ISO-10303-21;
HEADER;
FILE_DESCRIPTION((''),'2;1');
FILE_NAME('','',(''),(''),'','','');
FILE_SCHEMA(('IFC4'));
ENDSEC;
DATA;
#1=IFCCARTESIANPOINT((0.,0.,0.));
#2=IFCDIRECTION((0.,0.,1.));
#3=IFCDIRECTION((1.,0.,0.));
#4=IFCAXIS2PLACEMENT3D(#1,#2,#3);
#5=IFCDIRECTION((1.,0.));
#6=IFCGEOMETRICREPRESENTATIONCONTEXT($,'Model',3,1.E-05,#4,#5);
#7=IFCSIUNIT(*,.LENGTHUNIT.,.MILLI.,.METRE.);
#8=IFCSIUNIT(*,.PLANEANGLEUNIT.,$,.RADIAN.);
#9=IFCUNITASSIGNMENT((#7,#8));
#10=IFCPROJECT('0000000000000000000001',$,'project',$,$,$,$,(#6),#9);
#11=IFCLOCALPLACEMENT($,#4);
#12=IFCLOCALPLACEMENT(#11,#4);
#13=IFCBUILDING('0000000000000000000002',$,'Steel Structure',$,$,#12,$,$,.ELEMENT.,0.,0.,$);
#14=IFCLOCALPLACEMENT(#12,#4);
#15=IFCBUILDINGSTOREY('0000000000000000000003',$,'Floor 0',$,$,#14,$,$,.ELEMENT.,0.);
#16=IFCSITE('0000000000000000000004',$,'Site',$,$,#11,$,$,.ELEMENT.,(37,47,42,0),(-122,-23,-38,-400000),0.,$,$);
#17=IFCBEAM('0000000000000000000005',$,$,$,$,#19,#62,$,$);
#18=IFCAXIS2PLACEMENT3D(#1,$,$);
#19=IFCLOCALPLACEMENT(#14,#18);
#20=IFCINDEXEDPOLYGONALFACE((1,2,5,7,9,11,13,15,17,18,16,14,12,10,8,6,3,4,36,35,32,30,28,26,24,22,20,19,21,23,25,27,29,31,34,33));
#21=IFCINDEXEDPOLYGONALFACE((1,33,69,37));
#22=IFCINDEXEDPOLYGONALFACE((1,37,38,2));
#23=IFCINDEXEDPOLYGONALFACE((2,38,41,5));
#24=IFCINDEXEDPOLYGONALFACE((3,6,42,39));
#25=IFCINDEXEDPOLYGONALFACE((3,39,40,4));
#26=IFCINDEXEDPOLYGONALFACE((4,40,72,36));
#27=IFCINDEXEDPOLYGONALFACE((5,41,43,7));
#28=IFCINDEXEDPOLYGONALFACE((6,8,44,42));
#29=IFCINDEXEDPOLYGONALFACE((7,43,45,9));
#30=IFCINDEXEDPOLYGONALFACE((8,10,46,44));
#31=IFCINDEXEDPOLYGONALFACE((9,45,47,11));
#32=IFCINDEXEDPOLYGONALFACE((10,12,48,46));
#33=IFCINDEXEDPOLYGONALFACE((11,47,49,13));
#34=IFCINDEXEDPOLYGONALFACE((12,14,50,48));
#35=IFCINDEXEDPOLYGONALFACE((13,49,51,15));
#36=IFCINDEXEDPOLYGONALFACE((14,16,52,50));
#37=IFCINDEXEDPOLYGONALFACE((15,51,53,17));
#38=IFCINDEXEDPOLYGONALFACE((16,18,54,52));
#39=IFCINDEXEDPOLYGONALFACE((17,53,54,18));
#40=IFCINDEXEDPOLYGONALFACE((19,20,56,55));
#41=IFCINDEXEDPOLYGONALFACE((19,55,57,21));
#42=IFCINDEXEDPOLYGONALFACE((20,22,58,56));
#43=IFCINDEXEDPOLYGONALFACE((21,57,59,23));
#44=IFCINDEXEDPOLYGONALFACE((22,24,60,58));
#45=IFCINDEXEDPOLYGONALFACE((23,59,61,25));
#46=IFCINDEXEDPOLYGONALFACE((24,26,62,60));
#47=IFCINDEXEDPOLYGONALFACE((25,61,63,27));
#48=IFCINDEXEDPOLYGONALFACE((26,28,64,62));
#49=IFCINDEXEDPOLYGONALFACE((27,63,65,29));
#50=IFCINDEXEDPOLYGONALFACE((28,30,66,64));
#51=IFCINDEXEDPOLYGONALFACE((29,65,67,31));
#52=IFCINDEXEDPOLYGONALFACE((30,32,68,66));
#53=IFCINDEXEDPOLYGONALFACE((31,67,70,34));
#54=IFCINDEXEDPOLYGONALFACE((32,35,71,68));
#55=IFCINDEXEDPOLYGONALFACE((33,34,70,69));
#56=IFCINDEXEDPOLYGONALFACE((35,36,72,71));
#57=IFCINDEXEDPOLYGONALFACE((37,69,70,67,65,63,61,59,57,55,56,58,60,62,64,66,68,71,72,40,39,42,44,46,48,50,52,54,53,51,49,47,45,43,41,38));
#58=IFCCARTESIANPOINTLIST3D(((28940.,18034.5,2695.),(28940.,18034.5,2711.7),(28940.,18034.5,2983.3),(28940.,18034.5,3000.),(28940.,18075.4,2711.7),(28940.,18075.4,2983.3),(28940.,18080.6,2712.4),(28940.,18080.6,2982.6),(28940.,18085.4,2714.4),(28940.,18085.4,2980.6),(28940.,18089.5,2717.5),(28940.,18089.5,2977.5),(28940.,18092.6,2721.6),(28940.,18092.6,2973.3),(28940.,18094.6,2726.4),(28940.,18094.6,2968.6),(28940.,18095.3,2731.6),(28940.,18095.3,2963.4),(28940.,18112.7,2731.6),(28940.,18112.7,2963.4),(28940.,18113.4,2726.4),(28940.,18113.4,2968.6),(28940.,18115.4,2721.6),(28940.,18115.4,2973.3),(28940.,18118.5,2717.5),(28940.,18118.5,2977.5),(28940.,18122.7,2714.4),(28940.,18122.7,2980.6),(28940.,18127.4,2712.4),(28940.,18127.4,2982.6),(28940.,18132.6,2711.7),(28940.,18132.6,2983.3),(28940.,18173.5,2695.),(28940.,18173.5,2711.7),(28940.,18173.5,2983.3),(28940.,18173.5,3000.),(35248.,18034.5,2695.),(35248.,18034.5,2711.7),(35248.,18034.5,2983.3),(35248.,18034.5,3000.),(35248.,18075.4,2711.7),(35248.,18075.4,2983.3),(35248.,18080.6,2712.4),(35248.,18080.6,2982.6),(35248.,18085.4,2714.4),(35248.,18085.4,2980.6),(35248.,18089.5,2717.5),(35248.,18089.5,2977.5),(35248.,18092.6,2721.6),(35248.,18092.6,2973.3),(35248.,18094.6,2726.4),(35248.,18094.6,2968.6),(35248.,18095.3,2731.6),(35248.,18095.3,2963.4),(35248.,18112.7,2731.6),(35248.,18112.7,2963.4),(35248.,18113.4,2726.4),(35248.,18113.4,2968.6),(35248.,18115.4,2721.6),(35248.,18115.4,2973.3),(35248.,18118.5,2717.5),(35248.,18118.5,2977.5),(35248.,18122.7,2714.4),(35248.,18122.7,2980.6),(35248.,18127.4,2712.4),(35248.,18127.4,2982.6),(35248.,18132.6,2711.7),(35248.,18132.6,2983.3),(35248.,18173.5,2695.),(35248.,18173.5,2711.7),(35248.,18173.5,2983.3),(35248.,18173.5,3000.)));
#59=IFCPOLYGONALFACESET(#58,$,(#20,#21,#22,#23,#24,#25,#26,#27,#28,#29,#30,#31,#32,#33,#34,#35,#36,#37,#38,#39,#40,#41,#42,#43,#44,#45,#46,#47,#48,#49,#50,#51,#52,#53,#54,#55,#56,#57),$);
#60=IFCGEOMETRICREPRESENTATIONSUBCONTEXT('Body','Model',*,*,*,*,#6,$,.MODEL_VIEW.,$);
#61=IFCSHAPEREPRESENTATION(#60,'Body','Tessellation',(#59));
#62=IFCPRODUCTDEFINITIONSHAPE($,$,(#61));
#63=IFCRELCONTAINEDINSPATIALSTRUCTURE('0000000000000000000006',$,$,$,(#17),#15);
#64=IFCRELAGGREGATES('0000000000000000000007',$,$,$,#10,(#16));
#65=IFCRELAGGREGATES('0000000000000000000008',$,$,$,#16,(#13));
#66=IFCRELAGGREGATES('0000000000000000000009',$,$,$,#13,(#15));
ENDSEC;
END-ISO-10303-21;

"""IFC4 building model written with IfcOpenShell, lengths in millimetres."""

from ifc_helpers import new_model, si_unit, direction, frame, origin_with_axes, origin_2d_with_axis, place, context, subcontext, project, spatial, i_section, extrude, element, save


model = new_model("IFC4")

# Units and contexts
model_context = context("Model", 3, precision=1e-05, world=origin_with_axes(), true_north=direction((1.0, 0.0)))
body_context = subcontext(model_context, "Body", "Model", "MODEL_VIEW")
ifc_project = project(units=[si_unit("LENGTHUNIT", "METRE", prefix="MILLI"), si_unit("PLANEANGLEUNIT", "RADIAN")], contexts=[model_context])

# Site, building, storey
site_placement = place(None, origin_with_axes())
site = spatial("IfcSite", under=ifc_project, at=site_placement, Name="Site", CompositionType="ELEMENT", RefLatitude=(37, 47, 42, 0), RefLongitude=(-122, -23, -38, -400000), RefElevation=0.0)
building_placement = place(site_placement, origin_with_axes())
building = spatial("IfcBuilding", under=site, at=building_placement, Name="Steel Structure", CompositionType="ELEMENT", ElevationOfRefHeight=0.0, ElevationOfTerrain=0.0)
storey_placement = place(building_placement, origin_with_axes())
storey = spatial("IfcBuildingStorey", under=building, at=storey_placement, Name="Floor 0", CompositionType="ELEMENT", Elevation=0.0)

# Beam
beam_1_placement = place(storey_placement, frame((35248.0, 18104.0, 2695.0), z_axis=(-1.0, 0.0, 0.0), x_axis=(0.0, -1.0, 0.0)))
element("IfcBeam", 1, at=beam_1_placement, inside=storey, context=body_context, shape_type="SweptSolid", body=[
    extrude(i_section(OverallWidth=139.0, OverallDepth=305.0, WebThickness=17.4, FlangeThickness=16.7, FilletRadius=19.9, at=origin_2d_with_axis()), frame((0.0, 152.5, 0.0), z_axis=(0.0, 0.0, 1.0), x_axis=(1.0, 0.0, 0.0)), (0.0, 0.0, 1.0), 6308.0),
])

save(model, "model.ifc")
